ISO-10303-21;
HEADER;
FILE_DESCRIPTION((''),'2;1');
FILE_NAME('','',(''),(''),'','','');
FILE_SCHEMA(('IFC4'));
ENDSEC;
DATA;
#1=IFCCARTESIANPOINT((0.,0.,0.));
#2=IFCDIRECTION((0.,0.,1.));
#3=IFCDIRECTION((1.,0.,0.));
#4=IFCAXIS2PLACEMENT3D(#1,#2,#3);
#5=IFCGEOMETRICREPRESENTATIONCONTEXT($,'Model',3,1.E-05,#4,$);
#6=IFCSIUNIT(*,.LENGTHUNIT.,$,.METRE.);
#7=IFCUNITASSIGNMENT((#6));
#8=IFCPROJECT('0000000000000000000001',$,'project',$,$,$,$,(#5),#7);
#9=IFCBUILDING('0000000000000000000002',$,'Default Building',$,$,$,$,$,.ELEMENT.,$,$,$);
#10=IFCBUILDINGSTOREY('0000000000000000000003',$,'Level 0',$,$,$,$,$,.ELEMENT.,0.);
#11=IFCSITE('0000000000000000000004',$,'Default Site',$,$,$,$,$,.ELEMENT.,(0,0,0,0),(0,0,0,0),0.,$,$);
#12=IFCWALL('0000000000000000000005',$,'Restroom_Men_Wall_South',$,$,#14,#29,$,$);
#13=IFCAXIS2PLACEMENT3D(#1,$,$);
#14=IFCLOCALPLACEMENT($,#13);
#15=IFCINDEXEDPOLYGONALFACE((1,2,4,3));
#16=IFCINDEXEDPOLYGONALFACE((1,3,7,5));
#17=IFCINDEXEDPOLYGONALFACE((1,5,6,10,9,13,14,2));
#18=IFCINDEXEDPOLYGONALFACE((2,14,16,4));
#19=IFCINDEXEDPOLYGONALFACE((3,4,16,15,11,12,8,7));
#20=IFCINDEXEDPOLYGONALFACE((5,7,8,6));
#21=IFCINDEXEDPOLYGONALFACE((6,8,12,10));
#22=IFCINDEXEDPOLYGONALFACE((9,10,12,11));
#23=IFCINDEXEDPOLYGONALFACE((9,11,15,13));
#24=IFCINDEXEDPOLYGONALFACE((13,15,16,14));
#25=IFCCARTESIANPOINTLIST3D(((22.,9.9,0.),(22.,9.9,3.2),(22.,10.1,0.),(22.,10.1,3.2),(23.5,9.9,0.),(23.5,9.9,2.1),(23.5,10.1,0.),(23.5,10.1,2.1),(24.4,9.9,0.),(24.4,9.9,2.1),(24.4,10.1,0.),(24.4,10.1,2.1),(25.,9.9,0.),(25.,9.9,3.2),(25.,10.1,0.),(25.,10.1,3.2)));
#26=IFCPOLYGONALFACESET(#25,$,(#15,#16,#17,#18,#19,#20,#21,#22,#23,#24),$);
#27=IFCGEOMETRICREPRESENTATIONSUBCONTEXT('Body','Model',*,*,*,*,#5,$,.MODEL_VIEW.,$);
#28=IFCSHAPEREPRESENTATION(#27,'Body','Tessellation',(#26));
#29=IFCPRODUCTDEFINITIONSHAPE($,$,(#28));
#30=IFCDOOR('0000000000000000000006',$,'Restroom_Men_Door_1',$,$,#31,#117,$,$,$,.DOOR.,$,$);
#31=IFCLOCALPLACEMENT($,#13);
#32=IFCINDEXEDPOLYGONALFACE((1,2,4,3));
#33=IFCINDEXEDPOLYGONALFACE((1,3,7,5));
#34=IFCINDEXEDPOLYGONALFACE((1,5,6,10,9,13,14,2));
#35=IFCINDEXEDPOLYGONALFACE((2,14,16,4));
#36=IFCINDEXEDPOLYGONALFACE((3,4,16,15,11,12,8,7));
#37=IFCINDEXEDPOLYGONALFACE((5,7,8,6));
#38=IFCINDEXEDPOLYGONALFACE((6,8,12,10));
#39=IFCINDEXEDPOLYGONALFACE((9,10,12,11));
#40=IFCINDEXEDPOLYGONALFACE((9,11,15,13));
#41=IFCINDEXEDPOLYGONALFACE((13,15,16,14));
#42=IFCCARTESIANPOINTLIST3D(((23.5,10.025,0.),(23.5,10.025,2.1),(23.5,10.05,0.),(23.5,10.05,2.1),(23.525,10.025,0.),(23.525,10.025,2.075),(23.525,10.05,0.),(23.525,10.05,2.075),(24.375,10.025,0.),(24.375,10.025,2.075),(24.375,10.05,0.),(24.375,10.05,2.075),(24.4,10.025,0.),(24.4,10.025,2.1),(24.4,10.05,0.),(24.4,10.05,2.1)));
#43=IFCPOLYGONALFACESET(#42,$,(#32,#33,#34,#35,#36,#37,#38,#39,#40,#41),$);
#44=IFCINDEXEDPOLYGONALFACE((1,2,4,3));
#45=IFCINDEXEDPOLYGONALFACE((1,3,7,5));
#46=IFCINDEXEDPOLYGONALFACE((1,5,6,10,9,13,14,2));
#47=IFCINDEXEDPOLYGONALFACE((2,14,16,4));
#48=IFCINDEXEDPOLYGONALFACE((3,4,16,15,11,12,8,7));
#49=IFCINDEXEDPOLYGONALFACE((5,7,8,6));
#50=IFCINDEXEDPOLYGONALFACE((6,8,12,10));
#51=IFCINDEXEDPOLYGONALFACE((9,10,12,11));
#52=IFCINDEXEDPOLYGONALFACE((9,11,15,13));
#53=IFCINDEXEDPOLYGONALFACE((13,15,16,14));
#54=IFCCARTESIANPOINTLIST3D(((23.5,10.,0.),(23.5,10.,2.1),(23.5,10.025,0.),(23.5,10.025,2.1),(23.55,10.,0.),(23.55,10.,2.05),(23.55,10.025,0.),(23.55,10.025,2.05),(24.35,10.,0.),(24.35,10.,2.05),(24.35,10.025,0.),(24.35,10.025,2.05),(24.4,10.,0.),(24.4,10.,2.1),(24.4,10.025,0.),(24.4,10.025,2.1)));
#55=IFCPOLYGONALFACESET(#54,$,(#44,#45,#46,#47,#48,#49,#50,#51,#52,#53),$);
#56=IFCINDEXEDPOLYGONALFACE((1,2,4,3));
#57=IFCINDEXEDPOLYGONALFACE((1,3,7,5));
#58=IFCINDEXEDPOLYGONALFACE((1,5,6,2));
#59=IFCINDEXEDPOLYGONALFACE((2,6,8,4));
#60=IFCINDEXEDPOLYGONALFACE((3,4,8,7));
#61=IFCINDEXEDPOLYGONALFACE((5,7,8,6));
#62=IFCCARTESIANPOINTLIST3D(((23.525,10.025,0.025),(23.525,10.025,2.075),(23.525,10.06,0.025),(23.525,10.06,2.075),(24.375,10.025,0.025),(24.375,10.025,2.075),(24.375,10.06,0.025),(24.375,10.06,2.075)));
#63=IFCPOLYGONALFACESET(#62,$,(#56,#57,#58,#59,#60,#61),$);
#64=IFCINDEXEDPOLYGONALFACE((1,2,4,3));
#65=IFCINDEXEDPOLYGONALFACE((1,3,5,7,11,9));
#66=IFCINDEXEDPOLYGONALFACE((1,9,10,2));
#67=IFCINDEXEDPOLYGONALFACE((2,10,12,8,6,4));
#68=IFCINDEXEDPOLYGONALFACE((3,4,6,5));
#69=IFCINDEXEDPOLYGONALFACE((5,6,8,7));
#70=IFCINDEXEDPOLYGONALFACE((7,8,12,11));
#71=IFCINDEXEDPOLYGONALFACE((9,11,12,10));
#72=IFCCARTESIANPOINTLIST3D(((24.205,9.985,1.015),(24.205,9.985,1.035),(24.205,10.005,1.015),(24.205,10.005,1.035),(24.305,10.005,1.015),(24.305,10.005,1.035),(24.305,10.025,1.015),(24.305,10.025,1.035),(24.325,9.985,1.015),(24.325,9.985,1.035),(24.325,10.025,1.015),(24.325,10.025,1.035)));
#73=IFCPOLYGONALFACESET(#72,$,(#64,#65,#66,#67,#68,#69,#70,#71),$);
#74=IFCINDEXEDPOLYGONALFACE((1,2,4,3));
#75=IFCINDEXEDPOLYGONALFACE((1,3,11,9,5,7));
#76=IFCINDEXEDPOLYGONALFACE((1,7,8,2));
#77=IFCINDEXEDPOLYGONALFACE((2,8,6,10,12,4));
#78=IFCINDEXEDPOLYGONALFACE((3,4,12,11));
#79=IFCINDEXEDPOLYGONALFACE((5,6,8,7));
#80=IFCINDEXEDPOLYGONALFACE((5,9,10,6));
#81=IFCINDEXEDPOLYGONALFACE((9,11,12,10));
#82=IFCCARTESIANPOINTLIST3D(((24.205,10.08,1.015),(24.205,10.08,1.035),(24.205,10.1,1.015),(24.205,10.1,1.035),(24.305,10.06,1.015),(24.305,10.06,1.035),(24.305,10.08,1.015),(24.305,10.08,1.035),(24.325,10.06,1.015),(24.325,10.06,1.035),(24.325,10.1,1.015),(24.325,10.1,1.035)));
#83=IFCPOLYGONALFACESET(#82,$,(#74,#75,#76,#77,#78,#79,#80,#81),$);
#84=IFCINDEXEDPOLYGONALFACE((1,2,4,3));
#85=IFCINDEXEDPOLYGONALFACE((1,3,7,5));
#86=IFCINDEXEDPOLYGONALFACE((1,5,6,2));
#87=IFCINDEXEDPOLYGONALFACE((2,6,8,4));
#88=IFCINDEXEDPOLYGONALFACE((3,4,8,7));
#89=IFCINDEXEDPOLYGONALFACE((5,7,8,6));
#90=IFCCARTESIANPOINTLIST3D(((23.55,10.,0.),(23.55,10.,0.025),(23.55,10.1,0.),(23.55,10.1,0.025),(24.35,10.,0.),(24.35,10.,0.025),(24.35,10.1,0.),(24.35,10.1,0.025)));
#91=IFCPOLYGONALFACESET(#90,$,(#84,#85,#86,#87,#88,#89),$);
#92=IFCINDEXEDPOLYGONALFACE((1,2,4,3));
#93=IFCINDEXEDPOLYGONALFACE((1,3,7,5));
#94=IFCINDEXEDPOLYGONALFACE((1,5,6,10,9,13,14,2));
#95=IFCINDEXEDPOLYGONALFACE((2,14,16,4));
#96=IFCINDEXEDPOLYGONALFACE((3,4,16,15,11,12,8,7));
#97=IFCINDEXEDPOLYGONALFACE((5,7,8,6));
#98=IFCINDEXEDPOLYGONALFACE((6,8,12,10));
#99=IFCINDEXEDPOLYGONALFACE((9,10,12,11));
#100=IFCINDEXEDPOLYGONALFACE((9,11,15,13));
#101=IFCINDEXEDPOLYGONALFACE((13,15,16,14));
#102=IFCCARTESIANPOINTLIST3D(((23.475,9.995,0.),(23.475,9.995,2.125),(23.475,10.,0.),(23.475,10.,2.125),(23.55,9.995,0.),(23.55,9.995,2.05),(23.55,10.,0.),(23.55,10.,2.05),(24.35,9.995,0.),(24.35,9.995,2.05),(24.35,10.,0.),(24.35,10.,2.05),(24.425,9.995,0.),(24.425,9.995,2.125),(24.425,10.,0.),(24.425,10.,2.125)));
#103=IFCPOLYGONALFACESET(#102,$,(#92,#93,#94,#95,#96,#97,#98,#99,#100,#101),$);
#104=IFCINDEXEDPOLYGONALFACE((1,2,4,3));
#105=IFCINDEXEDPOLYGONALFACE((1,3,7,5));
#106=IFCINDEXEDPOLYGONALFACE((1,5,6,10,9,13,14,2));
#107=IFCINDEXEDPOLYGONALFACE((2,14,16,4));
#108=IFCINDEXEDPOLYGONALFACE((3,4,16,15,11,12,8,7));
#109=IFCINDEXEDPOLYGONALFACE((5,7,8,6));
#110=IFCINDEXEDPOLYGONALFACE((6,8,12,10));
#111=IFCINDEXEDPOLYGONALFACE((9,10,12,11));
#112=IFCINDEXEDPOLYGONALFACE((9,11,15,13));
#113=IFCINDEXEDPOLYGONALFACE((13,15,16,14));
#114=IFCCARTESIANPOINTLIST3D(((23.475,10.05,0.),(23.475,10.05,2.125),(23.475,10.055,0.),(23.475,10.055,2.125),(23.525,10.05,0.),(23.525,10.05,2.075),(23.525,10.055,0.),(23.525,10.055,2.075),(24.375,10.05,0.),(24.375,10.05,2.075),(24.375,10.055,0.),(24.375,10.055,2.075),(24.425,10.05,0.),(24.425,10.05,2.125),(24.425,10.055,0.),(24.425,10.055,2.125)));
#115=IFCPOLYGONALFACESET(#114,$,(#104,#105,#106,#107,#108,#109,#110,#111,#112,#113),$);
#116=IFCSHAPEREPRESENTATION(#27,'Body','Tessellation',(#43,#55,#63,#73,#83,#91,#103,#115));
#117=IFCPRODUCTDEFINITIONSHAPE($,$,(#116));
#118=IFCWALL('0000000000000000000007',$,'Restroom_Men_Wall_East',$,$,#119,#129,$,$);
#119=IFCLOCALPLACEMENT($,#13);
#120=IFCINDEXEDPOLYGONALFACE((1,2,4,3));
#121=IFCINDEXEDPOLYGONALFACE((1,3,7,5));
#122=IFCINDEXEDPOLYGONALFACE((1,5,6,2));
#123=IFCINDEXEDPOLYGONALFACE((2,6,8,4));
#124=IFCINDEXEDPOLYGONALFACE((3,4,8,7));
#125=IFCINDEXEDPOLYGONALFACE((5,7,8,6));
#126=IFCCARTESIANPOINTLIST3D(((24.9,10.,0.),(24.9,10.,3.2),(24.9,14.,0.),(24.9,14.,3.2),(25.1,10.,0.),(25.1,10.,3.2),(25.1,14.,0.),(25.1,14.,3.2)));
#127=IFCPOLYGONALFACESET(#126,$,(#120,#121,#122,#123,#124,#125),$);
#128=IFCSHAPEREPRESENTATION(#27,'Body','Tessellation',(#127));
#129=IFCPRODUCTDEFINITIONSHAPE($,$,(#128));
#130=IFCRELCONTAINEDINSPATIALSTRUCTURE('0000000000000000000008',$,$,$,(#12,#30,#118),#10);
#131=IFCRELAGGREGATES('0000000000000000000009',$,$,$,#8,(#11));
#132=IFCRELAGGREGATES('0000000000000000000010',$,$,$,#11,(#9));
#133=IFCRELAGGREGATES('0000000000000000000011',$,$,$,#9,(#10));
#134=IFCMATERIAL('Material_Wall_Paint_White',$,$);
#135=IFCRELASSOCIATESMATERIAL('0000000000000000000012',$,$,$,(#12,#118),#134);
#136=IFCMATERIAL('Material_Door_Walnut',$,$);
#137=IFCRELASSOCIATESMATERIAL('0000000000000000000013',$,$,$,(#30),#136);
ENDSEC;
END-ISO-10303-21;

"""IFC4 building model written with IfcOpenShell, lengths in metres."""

from ifc_helpers import new_model, si_unit, frame, origin_with_axes, place, context, subcontext, project, spatial, line, indexed_curve, outline, extrude, material, element, fill, save


model = new_model("IFC4")

# Units and contexts
model_context = context("Model", 3, precision=1e-05, world=origin_with_axes())
body_context = subcontext(model_context, "Body", "Model", "MODEL_VIEW")
ifc_project = project(units=[si_unit("LENGTHUNIT", "METRE")], contexts=[model_context])

# Site, building, storey
site = spatial("IfcSite", under=ifc_project, Name="Default Site", CompositionType="ELEMENT", RefLatitude=(0, 0, 0, 0), RefLongitude=(0, 0, 0, 0), RefElevation=0.0)
building = spatial("IfcBuilding", under=site, Name="Default Building", CompositionType="ELEMENT")
storey = spatial("IfcBuildingStorey", under=building, Name="Level 0", CompositionType="ELEMENT", Elevation=0.0)

# Shared definitions
ifc_material_1 = material(Name="Material_Wall_Paint_White")

# Shared definitions
ifc_material_2 = material(Name="Material_Door_Walnut")

# Wall, opening, door
wall_1_placement = place(None, frame((22.0, 10.0, 0.0), z_axis=(0.0, 0.0, 1.0), x_axis=(1.0, 0.0, 0.0)))
wall_1 = element("IfcWall", 1, at=wall_1_placement, inside=storey, material=ifc_material_1, Name="Restroom_Men_Wall_South", context=body_context, shape_type="SweptSolid", body=[
    extrude(outline(indexed_curve([(0.0, 0.0), (0.0, 0.2), (3.0, 0.2), (3.0, 0.0), (0.0, 0.0)], self_intersect=False)), frame((0.0, -0.1, 0.0), z_axis=(0.0, 0.0, 1.0), x_axis=(1.0, 0.0, 0.0)), (0.0, 0.0, 1.0), 3.2),
])
opening_1_placement = place(wall_1_placement, frame((1.5, -0.5, 0.0), z_axis=(0.0, 0.0, 1.0), x_axis=(1.0, 0.0, 0.0)))
opening_1 = element("IfcOpeningElement", 2, at=opening_1_placement, inside=storey, cuts=wall_1, PredefinedType="OPENING", context=body_context, shape_type="SweptSolid", body=[
    extrude(outline(indexed_curve([(0.0, 0.0), (0.0, 1.0), (0.9, 1.0), (0.9, 0.0), (0.0, 0.0)], self_intersect=False)), origin_with_axes(), (0.0, 0.0, 1.0), 2.1),
])
door_1_placement = place(None, frame((23.5, 10.0, 0.0), z_axis=(0.0, 0.0, 1.0), x_axis=(1.0, 0.0, 0.0)))
door_1 = element("IfcDoor", 3, at=door_1_placement, inside=storey, material=ifc_material_2, Name="Restroom_Men_Door_1", PredefinedType="DOOR", context=body_context, shape_type="SweptSolid", body=[
    extrude(outline(indexed_curve([(0.0, 0.0), (0.0, 2.1), (0.9, 2.1), (0.9, 0.0), (0.875, 0.0), (0.875, 2.075), (0.025, 2.075), (0.025, 0.0)], segments=[line(1, 2, 3, 4, 5, 6, 7, 8, 1)])), frame((0.0, 0.025, 0.0), z_axis=(0.0, -1.0, 0.0), x_axis=(1.0, 0.0, 0.0)), (0.0, 0.0, -1.0), 0.025),
    extrude(outline(indexed_curve([(0.0, 0.0), (0.0, 2.1), (0.9, 2.1), (0.9, 0.0), (0.85, 0.0), (0.85, 2.05), (0.05, 2.05), (0.05, 0.0)], segments=[line(1, 2, 3, 4, 5, 6, 7, 8, 1)])), frame((0.0, 0.0, 0.0), z_axis=(0.0, -1.0, 0.0), x_axis=(1.0, 0.0, 0.0)), (0.0, 0.0, -1.0), 0.025),
    extrude(outline(indexed_curve([(0.0, 0.0), (0.85, 0.0), (0.85, 0.035), (0.0, 0.035)], segments=[line(1, 2, 3, 4, 1)])), frame((0.025, 0.025, 0.025), z_axis=(0.0, 0.0, 1.0), x_axis=(1.0, 0.0, 0.0)), (0.0, 0.0, 1.0), 2.05),
    extrude(outline(indexed_curve([(0.0, 0.0), (0.0, -0.04), (-0.12, -0.04), (-0.12, -0.02), (-0.02, -0.02), (-0.02, 0.0)], segments=[line(1, 2, 3, 4, 5, 6, 1)])), frame((0.825, 0.025, 1.015), z_axis=(0.0, 0.0, 1.0), x_axis=(1.0, 0.0, 0.0)), (0.0, 0.0, 1.0), 0.02),
    extrude(outline(indexed_curve([(0.0, 0.0), (0.0, 0.04), (-0.12, 0.04), (-0.12, 0.02), (-0.02, 0.02), (-0.02, 0.0)], segments=[line(1, 2, 3, 4, 5, 6, 1)])), frame((0.825, 0.06, 1.015), z_axis=(0.0, 0.0, 1.0), x_axis=(1.0, 0.0, 0.0)), (0.0, 0.0, 1.0), 0.02),
    extrude(outline(indexed_curve([(0.0, 0.0), (0.8, 0.0), (0.8, 0.1), (0.0, 0.1)], segments=[line(1, 2, 3, 4, 1)])), frame((0.05, 0.0, 0.0), z_axis=(0.0, 0.0, 1.0), x_axis=(1.0, 0.0, 0.0)), (0.0, 0.0, 1.0), 0.025),
    extrude(outline(indexed_curve([(0.0, 0.0), (0.0, 2.125), (0.95, 2.125), (0.95, 0.0), (0.875, 0.0), (0.875, 2.05), (0.075, 2.05), (0.075, 0.0)], segments=[line(1, 2, 3, 4, 5, 6, 7, 8, 1)])), frame((-0.025, -0.005, 0.0), z_axis=(0.0, -1.0, 0.0), x_axis=(1.0, 0.0, 0.0)), (0.0, 0.0, -1.0), 0.005),
    extrude(outline(indexed_curve([(0.0, 0.0), (0.0, 2.125), (0.95, 2.125), (0.95, 0.0), (0.9, 0.0), (0.9, 2.075), (0.05, 2.075), (0.05, 0.0)], segments=[line(1, 2, 3, 4, 5, 6, 7, 8, 1)])), frame((-0.025, 0.05, 0.0), z_axis=(0.0, -1.0, 0.0), x_axis=(1.0, 0.0, 0.0)), (0.0, 0.0, -1.0), 0.005),
])
fill(opening_1, door_1)

# Wall
wall_2_placement = place(None, frame((25.0, 10.0, 0.0), z_axis=(0.0, 0.0, 1.0), x_axis=(0.0, 1.0, 0.0)))
element("IfcWall", 4, at=wall_2_placement, inside=storey, material=ifc_material_1, Name="Restroom_Men_Wall_East", context=body_context, shape_type="SweptSolid", body=[
    extrude(outline(indexed_curve([(0.0, 0.0), (0.0, 0.2), (4.0, 0.2), (4.0, 0.0), (0.0, 0.0)], self_intersect=False)), frame((0.0, -0.1, 0.0), z_axis=(0.0, 0.0, 1.0), x_axis=(1.0, 0.0, 0.0)), (0.0, 0.0, 1.0), 3.2),
])

save(model, "model.ifc")
